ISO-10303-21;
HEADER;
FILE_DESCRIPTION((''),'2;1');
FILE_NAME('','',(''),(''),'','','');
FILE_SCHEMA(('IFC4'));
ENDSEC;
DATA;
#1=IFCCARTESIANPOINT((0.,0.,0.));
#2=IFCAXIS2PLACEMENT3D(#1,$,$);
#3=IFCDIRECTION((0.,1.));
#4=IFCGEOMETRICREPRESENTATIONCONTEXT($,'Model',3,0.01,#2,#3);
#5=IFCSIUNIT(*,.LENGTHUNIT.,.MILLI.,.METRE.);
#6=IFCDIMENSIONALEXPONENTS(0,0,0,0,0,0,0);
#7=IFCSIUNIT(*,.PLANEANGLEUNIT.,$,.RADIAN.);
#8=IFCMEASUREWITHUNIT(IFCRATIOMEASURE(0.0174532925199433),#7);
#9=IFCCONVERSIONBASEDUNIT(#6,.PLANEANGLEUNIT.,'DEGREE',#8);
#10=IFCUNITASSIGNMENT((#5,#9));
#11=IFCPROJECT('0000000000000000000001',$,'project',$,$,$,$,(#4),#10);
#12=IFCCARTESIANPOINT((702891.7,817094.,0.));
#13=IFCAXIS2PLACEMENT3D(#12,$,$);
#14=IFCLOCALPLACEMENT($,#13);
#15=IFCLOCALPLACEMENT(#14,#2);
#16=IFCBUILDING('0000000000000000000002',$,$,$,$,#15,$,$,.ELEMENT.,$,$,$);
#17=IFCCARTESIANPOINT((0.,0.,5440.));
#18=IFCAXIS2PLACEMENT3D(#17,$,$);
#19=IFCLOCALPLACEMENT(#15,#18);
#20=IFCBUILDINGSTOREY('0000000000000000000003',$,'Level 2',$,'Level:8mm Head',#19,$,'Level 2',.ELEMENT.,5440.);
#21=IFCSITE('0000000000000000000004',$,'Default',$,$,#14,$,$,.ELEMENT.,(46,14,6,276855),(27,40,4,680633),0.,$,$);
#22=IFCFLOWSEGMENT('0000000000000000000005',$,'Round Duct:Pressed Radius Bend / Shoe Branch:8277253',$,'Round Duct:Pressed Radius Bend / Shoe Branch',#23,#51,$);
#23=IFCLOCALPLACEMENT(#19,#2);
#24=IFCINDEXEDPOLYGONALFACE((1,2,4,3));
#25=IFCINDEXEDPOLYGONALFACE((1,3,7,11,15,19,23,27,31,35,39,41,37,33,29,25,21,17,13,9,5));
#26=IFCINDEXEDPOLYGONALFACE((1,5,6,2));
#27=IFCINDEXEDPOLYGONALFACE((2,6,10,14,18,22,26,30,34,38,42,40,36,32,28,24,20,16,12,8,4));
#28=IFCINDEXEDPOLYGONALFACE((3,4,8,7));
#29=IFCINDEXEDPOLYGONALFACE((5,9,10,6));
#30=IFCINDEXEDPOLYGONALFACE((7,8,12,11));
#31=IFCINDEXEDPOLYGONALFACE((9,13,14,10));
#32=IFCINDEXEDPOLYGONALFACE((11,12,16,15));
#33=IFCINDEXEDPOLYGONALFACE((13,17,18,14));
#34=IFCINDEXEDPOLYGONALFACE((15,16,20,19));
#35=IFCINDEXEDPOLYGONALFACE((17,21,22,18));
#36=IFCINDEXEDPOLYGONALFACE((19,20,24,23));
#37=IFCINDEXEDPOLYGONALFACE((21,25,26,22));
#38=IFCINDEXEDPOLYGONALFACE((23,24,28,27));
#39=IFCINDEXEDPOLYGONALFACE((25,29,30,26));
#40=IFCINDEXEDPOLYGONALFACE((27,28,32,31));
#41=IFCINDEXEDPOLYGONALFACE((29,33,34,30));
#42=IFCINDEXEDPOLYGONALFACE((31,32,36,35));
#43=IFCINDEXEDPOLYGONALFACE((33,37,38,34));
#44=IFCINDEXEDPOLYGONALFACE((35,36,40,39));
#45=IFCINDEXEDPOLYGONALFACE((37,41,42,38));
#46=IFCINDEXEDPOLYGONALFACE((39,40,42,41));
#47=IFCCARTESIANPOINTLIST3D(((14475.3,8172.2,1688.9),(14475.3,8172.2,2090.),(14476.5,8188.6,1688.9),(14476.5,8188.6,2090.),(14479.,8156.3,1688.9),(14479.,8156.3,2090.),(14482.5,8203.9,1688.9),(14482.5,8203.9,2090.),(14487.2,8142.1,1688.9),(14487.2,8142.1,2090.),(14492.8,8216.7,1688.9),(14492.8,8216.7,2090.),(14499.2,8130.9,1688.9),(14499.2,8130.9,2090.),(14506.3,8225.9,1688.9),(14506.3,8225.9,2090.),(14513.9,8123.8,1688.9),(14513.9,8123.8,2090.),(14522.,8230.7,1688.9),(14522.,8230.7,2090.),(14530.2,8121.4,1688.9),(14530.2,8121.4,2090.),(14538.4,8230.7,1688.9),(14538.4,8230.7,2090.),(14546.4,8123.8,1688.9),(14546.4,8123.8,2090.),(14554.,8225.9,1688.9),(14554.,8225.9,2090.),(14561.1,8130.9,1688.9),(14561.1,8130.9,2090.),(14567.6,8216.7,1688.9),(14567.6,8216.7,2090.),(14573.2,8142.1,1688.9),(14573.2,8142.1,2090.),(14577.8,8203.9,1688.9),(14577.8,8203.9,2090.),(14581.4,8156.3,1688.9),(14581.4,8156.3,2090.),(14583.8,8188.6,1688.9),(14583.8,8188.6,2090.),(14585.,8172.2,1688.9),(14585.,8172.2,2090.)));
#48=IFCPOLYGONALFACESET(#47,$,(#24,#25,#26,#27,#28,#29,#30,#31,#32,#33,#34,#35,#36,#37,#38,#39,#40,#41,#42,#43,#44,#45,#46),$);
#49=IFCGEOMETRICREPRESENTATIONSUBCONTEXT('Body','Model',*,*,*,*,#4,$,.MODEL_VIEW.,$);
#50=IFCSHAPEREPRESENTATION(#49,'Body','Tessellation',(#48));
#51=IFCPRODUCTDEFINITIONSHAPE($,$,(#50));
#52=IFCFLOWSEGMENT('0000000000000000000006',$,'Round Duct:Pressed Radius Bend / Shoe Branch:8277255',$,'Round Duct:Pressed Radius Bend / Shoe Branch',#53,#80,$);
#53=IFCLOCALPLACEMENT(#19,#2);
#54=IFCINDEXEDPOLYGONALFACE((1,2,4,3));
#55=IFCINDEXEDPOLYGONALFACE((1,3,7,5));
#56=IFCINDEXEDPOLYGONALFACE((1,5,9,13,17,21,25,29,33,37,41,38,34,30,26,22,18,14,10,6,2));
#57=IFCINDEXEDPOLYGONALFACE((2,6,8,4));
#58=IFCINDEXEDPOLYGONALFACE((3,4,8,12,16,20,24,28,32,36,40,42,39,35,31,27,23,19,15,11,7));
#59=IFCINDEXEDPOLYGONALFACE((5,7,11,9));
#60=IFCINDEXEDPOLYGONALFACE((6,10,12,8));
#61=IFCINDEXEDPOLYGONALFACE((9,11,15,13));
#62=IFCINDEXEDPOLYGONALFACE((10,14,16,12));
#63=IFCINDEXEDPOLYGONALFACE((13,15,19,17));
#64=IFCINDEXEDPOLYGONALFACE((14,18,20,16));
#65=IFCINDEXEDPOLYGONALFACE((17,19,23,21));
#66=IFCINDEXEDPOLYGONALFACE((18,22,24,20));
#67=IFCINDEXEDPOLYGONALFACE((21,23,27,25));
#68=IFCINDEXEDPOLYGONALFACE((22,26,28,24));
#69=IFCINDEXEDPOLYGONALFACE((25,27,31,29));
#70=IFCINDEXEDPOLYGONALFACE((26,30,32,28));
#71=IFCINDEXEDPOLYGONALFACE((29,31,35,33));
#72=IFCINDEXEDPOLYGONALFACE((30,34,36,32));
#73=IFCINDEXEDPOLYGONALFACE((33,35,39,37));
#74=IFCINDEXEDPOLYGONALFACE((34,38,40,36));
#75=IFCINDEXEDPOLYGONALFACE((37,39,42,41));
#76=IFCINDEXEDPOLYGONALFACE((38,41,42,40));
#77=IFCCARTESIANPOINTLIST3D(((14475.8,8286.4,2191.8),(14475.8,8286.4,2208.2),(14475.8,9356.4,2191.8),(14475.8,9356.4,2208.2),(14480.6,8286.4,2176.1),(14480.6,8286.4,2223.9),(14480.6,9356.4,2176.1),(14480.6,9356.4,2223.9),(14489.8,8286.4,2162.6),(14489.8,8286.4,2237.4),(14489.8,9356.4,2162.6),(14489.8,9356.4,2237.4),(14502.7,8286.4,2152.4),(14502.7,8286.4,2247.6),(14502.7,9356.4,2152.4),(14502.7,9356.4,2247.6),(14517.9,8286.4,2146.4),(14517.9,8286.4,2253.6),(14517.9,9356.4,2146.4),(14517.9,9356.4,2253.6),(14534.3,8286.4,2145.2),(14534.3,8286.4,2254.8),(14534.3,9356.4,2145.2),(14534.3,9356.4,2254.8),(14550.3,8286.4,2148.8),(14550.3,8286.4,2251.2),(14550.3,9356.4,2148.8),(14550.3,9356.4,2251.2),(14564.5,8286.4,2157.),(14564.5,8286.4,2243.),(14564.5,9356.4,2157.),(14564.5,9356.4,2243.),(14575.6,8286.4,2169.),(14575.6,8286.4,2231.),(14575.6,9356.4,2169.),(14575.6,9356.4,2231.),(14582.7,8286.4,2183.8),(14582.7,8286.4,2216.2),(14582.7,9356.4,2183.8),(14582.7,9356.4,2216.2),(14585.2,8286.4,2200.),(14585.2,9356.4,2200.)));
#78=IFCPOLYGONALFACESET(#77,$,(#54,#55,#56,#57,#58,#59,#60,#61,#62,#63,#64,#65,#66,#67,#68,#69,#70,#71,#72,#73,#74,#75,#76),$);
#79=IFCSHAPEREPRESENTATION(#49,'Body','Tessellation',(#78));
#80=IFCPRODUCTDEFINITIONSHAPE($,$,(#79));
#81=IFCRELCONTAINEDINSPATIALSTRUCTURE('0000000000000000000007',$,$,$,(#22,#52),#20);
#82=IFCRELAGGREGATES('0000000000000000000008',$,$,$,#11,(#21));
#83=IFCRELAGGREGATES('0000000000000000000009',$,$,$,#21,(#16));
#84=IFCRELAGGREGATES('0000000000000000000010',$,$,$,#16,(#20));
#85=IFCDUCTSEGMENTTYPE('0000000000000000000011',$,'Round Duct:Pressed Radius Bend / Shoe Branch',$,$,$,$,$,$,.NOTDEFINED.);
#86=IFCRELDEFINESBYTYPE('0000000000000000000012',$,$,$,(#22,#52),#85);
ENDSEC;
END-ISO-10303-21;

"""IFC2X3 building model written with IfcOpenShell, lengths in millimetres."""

from ifc_helpers import new_model, entity, si_unit, converted_unit, direction, frame, origin, origin_2d_with_axis, place, context, subcontext, project, spatial, circle, extrude, type_object, element, save


model = new_model("IFC2X3")

# Units and contexts
model_context = context("Model", 3, precision=0.01, world=origin(), true_north=direction((0.0, 1.0)))
body_context = subcontext(model_context, "Body", "Model", "MODEL_VIEW")
ifc_project = project(units=[si_unit("LENGTHUNIT", "METRE", prefix="MILLI"), converted_unit("PLANEANGLEUNIT", "DEGREE", entity("IfcRatioMeasure", 0.0174532925199433), si_unit("PLANEANGLEUNIT", "RADIAN"), dimensions=[0, 0, 0, 0, 0, 0, 0])], contexts=[model_context])

# Site, building, storey
site_placement = place(None, frame((702891.7, 817094.0, 0.0)))
site = spatial("IfcSite", under=ifc_project, at=site_placement, Name="Default", CompositionType="ELEMENT", RefLatitude=(46, 14, 6, 276855), RefLongitude=(27, 40, 4, 680633), RefElevation=0.0)
building_placement = place(site_placement, origin())
building = spatial("IfcBuilding", under=site, at=building_placement, CompositionType="ELEMENT")
storey_placement = place(building_placement, frame((0.0, 0.0, 5440.0)))
storey = spatial("IfcBuildingStorey", under=building, at=storey_placement, Name="Level 2", ObjectType="Level:8mm Head", LongName="Level 2", CompositionType="ELEMENT", Elevation=5440.0)

# Flow segments
duct_segment_type = type_object("IfcDuctSegmentType", Name="Round Duct:Pressed Radius Bend / Shoe Branch", PredefinedType="NOTDEFINED")
flow_segment_1_placement = place(storey_placement, origin())
element("IfcFlowSegment", 1, at=flow_segment_1_placement, inside=storey, type_object=duct_segment_type, Name="Round Duct:Pressed Radius Bend / Shoe Branch:8277253", ObjectType="Round Duct:Pressed Radius Bend / Shoe Branch", context=body_context, shape_type="SweptSolid", body=[
    extrude(circle(Radius=55.0, at=origin_2d_with_axis()), frame((14530.2, 8176.4, 1688.9), z_axis=(0.0, 0.0, 1.0), x_axis=(0.0, -1.0, 0.0)), (0.0, 0.0, 1.0), 401.1),
])
flow_segment_2_placement = place(storey_placement, origin())
element("IfcFlowSegment", 2, at=flow_segment_2_placement, inside=storey, type_object=duct_segment_type, Name="Round Duct:Pressed Radius Bend / Shoe Branch:8277255", ObjectType="Round Duct:Pressed Radius Bend / Shoe Branch", context=body_context, shape_type="SweptSolid", body=[
    extrude(circle(Radius=55.0, at=origin_2d_with_axis()), frame((14530.2, 8286.4, 2200.0), z_axis=(0.0, 1.0, 0.0), x_axis=(1.0, 0.0, 0.0)), (0.0, 0.0, 1.0), 1070.0),
])

save(model, "model.ifc")
